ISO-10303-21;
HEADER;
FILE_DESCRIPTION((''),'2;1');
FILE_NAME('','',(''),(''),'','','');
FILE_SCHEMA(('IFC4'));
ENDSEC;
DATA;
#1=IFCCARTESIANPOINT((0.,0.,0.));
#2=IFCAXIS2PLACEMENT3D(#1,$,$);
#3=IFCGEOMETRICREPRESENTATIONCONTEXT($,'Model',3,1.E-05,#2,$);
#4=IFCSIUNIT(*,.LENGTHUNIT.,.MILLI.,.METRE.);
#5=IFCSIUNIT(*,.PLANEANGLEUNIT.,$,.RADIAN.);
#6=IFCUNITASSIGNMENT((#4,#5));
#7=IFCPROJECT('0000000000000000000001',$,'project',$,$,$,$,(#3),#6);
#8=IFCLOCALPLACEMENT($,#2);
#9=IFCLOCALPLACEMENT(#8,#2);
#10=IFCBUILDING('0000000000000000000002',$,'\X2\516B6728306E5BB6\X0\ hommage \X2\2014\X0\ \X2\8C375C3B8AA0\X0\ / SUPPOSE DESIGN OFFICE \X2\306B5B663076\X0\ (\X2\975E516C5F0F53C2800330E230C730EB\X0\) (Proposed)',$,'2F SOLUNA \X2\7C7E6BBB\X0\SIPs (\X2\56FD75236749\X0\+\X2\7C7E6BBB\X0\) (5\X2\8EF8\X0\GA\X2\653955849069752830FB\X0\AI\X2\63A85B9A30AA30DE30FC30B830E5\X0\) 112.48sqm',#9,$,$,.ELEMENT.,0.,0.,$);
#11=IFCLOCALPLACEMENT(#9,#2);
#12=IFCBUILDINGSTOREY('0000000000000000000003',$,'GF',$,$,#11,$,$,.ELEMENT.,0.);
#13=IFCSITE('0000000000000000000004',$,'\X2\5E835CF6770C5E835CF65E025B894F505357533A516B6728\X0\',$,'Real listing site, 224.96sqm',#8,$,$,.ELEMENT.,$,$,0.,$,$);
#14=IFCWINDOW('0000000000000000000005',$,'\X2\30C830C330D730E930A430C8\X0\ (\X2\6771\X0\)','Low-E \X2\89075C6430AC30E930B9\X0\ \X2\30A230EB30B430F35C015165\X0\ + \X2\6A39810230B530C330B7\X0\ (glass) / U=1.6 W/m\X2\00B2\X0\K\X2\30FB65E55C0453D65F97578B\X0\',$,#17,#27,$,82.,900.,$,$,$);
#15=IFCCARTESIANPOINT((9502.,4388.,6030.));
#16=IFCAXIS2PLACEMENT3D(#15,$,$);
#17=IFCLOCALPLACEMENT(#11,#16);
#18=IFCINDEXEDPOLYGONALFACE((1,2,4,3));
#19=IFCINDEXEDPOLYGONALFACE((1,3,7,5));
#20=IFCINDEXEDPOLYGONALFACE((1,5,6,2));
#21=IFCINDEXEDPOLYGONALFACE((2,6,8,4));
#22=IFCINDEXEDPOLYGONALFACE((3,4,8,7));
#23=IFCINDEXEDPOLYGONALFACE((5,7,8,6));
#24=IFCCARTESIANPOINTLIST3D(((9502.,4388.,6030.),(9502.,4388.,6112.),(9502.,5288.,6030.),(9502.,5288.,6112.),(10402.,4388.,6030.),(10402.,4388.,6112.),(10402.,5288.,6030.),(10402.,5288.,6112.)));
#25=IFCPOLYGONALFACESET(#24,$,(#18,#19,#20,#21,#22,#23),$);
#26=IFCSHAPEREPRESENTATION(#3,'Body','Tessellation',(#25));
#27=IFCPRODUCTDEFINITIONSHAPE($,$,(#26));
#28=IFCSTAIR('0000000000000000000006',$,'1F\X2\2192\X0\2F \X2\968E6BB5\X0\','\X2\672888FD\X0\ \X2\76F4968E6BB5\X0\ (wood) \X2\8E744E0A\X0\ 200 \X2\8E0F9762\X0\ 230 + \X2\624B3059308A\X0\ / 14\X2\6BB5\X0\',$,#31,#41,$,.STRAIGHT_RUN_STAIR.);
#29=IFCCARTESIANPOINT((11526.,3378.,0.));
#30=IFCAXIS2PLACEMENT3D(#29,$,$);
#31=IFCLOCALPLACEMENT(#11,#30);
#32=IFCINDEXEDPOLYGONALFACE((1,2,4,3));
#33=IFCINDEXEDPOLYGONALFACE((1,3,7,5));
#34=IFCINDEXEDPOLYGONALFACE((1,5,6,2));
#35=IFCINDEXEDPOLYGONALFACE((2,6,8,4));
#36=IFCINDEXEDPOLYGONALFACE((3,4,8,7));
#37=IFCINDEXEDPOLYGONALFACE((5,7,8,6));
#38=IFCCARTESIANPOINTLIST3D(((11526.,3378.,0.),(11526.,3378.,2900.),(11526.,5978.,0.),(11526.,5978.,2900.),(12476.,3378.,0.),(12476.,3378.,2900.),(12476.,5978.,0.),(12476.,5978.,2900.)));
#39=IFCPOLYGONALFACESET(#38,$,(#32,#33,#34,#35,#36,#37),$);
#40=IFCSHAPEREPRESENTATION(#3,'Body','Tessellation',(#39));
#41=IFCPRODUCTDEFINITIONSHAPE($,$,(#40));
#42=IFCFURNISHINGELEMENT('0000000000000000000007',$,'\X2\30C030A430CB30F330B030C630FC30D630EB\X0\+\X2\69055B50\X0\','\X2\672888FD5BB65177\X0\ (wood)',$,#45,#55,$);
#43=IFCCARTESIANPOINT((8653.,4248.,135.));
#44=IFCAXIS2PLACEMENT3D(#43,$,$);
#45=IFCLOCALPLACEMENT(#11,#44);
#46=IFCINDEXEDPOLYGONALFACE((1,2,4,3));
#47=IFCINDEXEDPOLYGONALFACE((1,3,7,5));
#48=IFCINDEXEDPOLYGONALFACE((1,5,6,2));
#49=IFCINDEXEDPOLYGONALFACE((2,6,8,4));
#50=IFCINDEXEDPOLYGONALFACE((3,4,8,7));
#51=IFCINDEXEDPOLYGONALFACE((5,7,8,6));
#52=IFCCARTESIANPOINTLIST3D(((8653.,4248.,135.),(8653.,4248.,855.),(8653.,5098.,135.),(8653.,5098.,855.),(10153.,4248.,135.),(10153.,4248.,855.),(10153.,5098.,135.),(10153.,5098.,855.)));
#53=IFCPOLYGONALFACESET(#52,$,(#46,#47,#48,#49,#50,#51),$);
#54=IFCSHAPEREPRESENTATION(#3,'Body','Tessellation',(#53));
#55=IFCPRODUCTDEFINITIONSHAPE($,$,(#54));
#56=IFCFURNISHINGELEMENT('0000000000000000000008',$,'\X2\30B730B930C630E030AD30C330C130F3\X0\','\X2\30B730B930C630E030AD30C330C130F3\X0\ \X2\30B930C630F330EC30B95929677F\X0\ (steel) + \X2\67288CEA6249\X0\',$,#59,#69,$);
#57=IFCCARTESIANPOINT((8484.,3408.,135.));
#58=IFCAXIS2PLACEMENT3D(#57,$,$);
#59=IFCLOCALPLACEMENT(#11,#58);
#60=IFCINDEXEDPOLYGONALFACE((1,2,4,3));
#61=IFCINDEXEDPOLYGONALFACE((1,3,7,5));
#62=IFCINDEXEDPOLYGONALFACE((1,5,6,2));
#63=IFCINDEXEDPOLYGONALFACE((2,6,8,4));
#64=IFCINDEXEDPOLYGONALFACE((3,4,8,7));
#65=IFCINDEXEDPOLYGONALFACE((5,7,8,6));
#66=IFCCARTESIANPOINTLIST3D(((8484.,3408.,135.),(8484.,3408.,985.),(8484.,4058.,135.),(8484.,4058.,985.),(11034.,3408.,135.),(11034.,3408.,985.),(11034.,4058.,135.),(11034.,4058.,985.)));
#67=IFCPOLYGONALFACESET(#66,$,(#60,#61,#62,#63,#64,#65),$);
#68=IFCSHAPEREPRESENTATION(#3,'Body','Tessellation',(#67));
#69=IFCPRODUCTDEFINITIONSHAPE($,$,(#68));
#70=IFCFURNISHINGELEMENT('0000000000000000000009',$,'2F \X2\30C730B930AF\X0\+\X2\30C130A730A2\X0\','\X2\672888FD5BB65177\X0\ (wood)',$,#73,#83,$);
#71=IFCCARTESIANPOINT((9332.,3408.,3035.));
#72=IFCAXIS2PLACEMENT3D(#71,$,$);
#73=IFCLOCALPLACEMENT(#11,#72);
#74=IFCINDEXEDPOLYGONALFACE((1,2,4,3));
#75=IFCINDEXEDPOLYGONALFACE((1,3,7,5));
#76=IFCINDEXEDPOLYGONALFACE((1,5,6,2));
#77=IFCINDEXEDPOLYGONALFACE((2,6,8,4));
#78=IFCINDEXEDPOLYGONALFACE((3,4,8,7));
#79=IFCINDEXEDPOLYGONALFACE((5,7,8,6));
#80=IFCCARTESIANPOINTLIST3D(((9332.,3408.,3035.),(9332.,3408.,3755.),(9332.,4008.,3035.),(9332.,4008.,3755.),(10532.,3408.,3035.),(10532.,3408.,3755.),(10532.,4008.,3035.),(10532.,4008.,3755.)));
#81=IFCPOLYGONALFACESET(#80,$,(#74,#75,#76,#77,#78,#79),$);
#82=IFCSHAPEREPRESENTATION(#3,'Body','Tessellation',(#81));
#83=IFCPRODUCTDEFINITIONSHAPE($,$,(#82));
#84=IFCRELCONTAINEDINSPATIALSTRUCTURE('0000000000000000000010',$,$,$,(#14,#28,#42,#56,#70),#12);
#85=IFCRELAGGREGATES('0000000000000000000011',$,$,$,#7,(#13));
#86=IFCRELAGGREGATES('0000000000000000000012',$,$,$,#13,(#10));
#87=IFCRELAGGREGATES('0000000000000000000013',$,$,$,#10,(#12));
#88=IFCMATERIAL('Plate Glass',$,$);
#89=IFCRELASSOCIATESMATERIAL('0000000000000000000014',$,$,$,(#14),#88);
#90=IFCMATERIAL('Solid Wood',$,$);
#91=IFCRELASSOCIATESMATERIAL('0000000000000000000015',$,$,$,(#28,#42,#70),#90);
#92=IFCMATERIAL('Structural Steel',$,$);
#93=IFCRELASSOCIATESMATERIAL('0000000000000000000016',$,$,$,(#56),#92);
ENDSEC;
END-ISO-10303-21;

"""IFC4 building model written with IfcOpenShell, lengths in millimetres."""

from ifc_helpers import new_model, si_unit, frame, frame_2d, origin, place, context, project, spatial, rectangle, extrude, material, element, save


model = new_model("IFC4")

# Units and contexts
model_context = context("Model", 3, precision=1e-05, world=origin())
ifc_project = project(units=[si_unit("LENGTHUNIT", "METRE", prefix="MILLI"), si_unit("PLANEANGLEUNIT", "RADIAN")], contexts=[model_context])

# Site, building, storey
site_placement = place(None, origin())
site = spatial("IfcSite", under=ifc_project, at=site_placement, Name="広島県広島市安佐南区八木", ObjectType="Real listing site, 224.96sqm", CompositionType="ELEMENT", RefElevation=0.0)
building_placement = place(site_placement, origin())
building = spatial("IfcBuilding", under=site, at=building_placement, Name="八木の家 hommage — 谷尻誠 / SUPPOSE DESIGN OFFICE に学ぶ (非公式参考モデル) (Proposed)", ObjectType="2F SOLUNA 籾殻SIPs (国産杉+籾殻) (5軸GA改善適用・AI推定オマージュ) 112.48sqm", CompositionType="ELEMENT", ElevationOfRefHeight=0.0, ElevationOfTerrain=0.0)
storey_placement = place(building_placement, origin())
storey = spatial("IfcBuildingStorey", under=building, at=storey_placement, Name="GF", CompositionType="ELEMENT", Elevation=0.0)

# Shared definitions
ifc_material_1 = material(Name="Solid Wood")

# Shared definitions
ifc_material_2 = material(Name="Plate Glass")

# Window
window_1_placement = place(storey_placement, frame((9502.0, 4388.0, 6030.0)))
element("IfcWindow", 1, at=window_1_placement, inside=storey, material=ifc_material_2, Name="トップライト (東)", Description="Low-E 複層ガラス アルゴン封入 + 樹脂サッシ (glass) / U=1.6 W/m²K・日射取得型", OverallHeight=82.0, OverallWidth=900.0, context=model_context, shape_type="SweptSolid", body=[
    extrude(rectangle(XDim=900.0, YDim=900.0, at=frame_2d((450.0, 450.0))), frame((9502.0, 4388.0, 6030.0)), (0.0, 0.0, 1.0), 82.0),
])

# Stair
stair_placement = place(storey_placement, frame((11526.0, 3378.0, 0.0)))
element("IfcStair", 2, at=stair_placement, inside=storey, material=ifc_material_1, Name="1F→2F 階段", Description="木製 直階段 (wood) 蹴上 200 踏面 230 + 手すり / 14段", PredefinedType="STRAIGHT_RUN_STAIR", context=model_context, shape_type="SweptSolid", body=[
    extrude(rectangle(XDim=950.0, YDim=2600.0, at=frame_2d((475.0, 1300.0))), frame((11526.0, 3378.0, 0.0)), (0.0, 0.0, 1.0), 2900.0),
])

# Furnishing elements
furnishing_1_placement = place(storey_placement, frame((8653.0, 4248.0, 135.0)))
element("IfcFurnishingElement", 3, at=furnishing_1_placement, inside=storey, material=ifc_material_1, Name="ダイニングテーブル+椅子", Description="木製家具 (wood)", context=model_context, shape_type="SweptSolid", body=[
    extrude(rectangle(XDim=1500.0, YDim=850.0, at=frame_2d((750.0, 425.0))), frame((8653.0, 4248.0, 135.0)), (0.0, 0.0, 1.0), 720.0),
])
ifc_material_3 = material(Name="Structural Steel")
furnishing_2_placement = place(storey_placement, frame((8484.0, 3408.0, 135.0)))
element("IfcFurnishingElement", 4, at=furnishing_2_placement, inside=storey, material=ifc_material_3, Name="システムキッチン", Description="システムキッチン ステンレス天板 (steel) + 木質扉", context=model_context, shape_type="SweptSolid", body=[
    extrude(rectangle(XDim=2550.0, YDim=650.0, at=frame_2d((1275.0, 325.0))), frame((8484.0, 3408.0, 135.0)), (0.0, 0.0, 1.0), 850.0),
])
furnishing_3_placement = place(storey_placement, frame((9332.0, 3408.0, 3035.0)))
element("IfcFurnishingElement", 5, at=furnishing_3_placement, inside=storey, material=ifc_material_1, Name="2F デスク+チェア", Description="木製家具 (wood)", context=model_context, shape_type="SweptSolid", body=[
    extrude(rectangle(XDim=1200.0, YDim=600.0, at=frame_2d((600.0, 300.0))), frame((9332.0, 3408.0, 3035.0)), (0.0, 0.0, 1.0), 720.0),
])

save(model, "model.ifc")
